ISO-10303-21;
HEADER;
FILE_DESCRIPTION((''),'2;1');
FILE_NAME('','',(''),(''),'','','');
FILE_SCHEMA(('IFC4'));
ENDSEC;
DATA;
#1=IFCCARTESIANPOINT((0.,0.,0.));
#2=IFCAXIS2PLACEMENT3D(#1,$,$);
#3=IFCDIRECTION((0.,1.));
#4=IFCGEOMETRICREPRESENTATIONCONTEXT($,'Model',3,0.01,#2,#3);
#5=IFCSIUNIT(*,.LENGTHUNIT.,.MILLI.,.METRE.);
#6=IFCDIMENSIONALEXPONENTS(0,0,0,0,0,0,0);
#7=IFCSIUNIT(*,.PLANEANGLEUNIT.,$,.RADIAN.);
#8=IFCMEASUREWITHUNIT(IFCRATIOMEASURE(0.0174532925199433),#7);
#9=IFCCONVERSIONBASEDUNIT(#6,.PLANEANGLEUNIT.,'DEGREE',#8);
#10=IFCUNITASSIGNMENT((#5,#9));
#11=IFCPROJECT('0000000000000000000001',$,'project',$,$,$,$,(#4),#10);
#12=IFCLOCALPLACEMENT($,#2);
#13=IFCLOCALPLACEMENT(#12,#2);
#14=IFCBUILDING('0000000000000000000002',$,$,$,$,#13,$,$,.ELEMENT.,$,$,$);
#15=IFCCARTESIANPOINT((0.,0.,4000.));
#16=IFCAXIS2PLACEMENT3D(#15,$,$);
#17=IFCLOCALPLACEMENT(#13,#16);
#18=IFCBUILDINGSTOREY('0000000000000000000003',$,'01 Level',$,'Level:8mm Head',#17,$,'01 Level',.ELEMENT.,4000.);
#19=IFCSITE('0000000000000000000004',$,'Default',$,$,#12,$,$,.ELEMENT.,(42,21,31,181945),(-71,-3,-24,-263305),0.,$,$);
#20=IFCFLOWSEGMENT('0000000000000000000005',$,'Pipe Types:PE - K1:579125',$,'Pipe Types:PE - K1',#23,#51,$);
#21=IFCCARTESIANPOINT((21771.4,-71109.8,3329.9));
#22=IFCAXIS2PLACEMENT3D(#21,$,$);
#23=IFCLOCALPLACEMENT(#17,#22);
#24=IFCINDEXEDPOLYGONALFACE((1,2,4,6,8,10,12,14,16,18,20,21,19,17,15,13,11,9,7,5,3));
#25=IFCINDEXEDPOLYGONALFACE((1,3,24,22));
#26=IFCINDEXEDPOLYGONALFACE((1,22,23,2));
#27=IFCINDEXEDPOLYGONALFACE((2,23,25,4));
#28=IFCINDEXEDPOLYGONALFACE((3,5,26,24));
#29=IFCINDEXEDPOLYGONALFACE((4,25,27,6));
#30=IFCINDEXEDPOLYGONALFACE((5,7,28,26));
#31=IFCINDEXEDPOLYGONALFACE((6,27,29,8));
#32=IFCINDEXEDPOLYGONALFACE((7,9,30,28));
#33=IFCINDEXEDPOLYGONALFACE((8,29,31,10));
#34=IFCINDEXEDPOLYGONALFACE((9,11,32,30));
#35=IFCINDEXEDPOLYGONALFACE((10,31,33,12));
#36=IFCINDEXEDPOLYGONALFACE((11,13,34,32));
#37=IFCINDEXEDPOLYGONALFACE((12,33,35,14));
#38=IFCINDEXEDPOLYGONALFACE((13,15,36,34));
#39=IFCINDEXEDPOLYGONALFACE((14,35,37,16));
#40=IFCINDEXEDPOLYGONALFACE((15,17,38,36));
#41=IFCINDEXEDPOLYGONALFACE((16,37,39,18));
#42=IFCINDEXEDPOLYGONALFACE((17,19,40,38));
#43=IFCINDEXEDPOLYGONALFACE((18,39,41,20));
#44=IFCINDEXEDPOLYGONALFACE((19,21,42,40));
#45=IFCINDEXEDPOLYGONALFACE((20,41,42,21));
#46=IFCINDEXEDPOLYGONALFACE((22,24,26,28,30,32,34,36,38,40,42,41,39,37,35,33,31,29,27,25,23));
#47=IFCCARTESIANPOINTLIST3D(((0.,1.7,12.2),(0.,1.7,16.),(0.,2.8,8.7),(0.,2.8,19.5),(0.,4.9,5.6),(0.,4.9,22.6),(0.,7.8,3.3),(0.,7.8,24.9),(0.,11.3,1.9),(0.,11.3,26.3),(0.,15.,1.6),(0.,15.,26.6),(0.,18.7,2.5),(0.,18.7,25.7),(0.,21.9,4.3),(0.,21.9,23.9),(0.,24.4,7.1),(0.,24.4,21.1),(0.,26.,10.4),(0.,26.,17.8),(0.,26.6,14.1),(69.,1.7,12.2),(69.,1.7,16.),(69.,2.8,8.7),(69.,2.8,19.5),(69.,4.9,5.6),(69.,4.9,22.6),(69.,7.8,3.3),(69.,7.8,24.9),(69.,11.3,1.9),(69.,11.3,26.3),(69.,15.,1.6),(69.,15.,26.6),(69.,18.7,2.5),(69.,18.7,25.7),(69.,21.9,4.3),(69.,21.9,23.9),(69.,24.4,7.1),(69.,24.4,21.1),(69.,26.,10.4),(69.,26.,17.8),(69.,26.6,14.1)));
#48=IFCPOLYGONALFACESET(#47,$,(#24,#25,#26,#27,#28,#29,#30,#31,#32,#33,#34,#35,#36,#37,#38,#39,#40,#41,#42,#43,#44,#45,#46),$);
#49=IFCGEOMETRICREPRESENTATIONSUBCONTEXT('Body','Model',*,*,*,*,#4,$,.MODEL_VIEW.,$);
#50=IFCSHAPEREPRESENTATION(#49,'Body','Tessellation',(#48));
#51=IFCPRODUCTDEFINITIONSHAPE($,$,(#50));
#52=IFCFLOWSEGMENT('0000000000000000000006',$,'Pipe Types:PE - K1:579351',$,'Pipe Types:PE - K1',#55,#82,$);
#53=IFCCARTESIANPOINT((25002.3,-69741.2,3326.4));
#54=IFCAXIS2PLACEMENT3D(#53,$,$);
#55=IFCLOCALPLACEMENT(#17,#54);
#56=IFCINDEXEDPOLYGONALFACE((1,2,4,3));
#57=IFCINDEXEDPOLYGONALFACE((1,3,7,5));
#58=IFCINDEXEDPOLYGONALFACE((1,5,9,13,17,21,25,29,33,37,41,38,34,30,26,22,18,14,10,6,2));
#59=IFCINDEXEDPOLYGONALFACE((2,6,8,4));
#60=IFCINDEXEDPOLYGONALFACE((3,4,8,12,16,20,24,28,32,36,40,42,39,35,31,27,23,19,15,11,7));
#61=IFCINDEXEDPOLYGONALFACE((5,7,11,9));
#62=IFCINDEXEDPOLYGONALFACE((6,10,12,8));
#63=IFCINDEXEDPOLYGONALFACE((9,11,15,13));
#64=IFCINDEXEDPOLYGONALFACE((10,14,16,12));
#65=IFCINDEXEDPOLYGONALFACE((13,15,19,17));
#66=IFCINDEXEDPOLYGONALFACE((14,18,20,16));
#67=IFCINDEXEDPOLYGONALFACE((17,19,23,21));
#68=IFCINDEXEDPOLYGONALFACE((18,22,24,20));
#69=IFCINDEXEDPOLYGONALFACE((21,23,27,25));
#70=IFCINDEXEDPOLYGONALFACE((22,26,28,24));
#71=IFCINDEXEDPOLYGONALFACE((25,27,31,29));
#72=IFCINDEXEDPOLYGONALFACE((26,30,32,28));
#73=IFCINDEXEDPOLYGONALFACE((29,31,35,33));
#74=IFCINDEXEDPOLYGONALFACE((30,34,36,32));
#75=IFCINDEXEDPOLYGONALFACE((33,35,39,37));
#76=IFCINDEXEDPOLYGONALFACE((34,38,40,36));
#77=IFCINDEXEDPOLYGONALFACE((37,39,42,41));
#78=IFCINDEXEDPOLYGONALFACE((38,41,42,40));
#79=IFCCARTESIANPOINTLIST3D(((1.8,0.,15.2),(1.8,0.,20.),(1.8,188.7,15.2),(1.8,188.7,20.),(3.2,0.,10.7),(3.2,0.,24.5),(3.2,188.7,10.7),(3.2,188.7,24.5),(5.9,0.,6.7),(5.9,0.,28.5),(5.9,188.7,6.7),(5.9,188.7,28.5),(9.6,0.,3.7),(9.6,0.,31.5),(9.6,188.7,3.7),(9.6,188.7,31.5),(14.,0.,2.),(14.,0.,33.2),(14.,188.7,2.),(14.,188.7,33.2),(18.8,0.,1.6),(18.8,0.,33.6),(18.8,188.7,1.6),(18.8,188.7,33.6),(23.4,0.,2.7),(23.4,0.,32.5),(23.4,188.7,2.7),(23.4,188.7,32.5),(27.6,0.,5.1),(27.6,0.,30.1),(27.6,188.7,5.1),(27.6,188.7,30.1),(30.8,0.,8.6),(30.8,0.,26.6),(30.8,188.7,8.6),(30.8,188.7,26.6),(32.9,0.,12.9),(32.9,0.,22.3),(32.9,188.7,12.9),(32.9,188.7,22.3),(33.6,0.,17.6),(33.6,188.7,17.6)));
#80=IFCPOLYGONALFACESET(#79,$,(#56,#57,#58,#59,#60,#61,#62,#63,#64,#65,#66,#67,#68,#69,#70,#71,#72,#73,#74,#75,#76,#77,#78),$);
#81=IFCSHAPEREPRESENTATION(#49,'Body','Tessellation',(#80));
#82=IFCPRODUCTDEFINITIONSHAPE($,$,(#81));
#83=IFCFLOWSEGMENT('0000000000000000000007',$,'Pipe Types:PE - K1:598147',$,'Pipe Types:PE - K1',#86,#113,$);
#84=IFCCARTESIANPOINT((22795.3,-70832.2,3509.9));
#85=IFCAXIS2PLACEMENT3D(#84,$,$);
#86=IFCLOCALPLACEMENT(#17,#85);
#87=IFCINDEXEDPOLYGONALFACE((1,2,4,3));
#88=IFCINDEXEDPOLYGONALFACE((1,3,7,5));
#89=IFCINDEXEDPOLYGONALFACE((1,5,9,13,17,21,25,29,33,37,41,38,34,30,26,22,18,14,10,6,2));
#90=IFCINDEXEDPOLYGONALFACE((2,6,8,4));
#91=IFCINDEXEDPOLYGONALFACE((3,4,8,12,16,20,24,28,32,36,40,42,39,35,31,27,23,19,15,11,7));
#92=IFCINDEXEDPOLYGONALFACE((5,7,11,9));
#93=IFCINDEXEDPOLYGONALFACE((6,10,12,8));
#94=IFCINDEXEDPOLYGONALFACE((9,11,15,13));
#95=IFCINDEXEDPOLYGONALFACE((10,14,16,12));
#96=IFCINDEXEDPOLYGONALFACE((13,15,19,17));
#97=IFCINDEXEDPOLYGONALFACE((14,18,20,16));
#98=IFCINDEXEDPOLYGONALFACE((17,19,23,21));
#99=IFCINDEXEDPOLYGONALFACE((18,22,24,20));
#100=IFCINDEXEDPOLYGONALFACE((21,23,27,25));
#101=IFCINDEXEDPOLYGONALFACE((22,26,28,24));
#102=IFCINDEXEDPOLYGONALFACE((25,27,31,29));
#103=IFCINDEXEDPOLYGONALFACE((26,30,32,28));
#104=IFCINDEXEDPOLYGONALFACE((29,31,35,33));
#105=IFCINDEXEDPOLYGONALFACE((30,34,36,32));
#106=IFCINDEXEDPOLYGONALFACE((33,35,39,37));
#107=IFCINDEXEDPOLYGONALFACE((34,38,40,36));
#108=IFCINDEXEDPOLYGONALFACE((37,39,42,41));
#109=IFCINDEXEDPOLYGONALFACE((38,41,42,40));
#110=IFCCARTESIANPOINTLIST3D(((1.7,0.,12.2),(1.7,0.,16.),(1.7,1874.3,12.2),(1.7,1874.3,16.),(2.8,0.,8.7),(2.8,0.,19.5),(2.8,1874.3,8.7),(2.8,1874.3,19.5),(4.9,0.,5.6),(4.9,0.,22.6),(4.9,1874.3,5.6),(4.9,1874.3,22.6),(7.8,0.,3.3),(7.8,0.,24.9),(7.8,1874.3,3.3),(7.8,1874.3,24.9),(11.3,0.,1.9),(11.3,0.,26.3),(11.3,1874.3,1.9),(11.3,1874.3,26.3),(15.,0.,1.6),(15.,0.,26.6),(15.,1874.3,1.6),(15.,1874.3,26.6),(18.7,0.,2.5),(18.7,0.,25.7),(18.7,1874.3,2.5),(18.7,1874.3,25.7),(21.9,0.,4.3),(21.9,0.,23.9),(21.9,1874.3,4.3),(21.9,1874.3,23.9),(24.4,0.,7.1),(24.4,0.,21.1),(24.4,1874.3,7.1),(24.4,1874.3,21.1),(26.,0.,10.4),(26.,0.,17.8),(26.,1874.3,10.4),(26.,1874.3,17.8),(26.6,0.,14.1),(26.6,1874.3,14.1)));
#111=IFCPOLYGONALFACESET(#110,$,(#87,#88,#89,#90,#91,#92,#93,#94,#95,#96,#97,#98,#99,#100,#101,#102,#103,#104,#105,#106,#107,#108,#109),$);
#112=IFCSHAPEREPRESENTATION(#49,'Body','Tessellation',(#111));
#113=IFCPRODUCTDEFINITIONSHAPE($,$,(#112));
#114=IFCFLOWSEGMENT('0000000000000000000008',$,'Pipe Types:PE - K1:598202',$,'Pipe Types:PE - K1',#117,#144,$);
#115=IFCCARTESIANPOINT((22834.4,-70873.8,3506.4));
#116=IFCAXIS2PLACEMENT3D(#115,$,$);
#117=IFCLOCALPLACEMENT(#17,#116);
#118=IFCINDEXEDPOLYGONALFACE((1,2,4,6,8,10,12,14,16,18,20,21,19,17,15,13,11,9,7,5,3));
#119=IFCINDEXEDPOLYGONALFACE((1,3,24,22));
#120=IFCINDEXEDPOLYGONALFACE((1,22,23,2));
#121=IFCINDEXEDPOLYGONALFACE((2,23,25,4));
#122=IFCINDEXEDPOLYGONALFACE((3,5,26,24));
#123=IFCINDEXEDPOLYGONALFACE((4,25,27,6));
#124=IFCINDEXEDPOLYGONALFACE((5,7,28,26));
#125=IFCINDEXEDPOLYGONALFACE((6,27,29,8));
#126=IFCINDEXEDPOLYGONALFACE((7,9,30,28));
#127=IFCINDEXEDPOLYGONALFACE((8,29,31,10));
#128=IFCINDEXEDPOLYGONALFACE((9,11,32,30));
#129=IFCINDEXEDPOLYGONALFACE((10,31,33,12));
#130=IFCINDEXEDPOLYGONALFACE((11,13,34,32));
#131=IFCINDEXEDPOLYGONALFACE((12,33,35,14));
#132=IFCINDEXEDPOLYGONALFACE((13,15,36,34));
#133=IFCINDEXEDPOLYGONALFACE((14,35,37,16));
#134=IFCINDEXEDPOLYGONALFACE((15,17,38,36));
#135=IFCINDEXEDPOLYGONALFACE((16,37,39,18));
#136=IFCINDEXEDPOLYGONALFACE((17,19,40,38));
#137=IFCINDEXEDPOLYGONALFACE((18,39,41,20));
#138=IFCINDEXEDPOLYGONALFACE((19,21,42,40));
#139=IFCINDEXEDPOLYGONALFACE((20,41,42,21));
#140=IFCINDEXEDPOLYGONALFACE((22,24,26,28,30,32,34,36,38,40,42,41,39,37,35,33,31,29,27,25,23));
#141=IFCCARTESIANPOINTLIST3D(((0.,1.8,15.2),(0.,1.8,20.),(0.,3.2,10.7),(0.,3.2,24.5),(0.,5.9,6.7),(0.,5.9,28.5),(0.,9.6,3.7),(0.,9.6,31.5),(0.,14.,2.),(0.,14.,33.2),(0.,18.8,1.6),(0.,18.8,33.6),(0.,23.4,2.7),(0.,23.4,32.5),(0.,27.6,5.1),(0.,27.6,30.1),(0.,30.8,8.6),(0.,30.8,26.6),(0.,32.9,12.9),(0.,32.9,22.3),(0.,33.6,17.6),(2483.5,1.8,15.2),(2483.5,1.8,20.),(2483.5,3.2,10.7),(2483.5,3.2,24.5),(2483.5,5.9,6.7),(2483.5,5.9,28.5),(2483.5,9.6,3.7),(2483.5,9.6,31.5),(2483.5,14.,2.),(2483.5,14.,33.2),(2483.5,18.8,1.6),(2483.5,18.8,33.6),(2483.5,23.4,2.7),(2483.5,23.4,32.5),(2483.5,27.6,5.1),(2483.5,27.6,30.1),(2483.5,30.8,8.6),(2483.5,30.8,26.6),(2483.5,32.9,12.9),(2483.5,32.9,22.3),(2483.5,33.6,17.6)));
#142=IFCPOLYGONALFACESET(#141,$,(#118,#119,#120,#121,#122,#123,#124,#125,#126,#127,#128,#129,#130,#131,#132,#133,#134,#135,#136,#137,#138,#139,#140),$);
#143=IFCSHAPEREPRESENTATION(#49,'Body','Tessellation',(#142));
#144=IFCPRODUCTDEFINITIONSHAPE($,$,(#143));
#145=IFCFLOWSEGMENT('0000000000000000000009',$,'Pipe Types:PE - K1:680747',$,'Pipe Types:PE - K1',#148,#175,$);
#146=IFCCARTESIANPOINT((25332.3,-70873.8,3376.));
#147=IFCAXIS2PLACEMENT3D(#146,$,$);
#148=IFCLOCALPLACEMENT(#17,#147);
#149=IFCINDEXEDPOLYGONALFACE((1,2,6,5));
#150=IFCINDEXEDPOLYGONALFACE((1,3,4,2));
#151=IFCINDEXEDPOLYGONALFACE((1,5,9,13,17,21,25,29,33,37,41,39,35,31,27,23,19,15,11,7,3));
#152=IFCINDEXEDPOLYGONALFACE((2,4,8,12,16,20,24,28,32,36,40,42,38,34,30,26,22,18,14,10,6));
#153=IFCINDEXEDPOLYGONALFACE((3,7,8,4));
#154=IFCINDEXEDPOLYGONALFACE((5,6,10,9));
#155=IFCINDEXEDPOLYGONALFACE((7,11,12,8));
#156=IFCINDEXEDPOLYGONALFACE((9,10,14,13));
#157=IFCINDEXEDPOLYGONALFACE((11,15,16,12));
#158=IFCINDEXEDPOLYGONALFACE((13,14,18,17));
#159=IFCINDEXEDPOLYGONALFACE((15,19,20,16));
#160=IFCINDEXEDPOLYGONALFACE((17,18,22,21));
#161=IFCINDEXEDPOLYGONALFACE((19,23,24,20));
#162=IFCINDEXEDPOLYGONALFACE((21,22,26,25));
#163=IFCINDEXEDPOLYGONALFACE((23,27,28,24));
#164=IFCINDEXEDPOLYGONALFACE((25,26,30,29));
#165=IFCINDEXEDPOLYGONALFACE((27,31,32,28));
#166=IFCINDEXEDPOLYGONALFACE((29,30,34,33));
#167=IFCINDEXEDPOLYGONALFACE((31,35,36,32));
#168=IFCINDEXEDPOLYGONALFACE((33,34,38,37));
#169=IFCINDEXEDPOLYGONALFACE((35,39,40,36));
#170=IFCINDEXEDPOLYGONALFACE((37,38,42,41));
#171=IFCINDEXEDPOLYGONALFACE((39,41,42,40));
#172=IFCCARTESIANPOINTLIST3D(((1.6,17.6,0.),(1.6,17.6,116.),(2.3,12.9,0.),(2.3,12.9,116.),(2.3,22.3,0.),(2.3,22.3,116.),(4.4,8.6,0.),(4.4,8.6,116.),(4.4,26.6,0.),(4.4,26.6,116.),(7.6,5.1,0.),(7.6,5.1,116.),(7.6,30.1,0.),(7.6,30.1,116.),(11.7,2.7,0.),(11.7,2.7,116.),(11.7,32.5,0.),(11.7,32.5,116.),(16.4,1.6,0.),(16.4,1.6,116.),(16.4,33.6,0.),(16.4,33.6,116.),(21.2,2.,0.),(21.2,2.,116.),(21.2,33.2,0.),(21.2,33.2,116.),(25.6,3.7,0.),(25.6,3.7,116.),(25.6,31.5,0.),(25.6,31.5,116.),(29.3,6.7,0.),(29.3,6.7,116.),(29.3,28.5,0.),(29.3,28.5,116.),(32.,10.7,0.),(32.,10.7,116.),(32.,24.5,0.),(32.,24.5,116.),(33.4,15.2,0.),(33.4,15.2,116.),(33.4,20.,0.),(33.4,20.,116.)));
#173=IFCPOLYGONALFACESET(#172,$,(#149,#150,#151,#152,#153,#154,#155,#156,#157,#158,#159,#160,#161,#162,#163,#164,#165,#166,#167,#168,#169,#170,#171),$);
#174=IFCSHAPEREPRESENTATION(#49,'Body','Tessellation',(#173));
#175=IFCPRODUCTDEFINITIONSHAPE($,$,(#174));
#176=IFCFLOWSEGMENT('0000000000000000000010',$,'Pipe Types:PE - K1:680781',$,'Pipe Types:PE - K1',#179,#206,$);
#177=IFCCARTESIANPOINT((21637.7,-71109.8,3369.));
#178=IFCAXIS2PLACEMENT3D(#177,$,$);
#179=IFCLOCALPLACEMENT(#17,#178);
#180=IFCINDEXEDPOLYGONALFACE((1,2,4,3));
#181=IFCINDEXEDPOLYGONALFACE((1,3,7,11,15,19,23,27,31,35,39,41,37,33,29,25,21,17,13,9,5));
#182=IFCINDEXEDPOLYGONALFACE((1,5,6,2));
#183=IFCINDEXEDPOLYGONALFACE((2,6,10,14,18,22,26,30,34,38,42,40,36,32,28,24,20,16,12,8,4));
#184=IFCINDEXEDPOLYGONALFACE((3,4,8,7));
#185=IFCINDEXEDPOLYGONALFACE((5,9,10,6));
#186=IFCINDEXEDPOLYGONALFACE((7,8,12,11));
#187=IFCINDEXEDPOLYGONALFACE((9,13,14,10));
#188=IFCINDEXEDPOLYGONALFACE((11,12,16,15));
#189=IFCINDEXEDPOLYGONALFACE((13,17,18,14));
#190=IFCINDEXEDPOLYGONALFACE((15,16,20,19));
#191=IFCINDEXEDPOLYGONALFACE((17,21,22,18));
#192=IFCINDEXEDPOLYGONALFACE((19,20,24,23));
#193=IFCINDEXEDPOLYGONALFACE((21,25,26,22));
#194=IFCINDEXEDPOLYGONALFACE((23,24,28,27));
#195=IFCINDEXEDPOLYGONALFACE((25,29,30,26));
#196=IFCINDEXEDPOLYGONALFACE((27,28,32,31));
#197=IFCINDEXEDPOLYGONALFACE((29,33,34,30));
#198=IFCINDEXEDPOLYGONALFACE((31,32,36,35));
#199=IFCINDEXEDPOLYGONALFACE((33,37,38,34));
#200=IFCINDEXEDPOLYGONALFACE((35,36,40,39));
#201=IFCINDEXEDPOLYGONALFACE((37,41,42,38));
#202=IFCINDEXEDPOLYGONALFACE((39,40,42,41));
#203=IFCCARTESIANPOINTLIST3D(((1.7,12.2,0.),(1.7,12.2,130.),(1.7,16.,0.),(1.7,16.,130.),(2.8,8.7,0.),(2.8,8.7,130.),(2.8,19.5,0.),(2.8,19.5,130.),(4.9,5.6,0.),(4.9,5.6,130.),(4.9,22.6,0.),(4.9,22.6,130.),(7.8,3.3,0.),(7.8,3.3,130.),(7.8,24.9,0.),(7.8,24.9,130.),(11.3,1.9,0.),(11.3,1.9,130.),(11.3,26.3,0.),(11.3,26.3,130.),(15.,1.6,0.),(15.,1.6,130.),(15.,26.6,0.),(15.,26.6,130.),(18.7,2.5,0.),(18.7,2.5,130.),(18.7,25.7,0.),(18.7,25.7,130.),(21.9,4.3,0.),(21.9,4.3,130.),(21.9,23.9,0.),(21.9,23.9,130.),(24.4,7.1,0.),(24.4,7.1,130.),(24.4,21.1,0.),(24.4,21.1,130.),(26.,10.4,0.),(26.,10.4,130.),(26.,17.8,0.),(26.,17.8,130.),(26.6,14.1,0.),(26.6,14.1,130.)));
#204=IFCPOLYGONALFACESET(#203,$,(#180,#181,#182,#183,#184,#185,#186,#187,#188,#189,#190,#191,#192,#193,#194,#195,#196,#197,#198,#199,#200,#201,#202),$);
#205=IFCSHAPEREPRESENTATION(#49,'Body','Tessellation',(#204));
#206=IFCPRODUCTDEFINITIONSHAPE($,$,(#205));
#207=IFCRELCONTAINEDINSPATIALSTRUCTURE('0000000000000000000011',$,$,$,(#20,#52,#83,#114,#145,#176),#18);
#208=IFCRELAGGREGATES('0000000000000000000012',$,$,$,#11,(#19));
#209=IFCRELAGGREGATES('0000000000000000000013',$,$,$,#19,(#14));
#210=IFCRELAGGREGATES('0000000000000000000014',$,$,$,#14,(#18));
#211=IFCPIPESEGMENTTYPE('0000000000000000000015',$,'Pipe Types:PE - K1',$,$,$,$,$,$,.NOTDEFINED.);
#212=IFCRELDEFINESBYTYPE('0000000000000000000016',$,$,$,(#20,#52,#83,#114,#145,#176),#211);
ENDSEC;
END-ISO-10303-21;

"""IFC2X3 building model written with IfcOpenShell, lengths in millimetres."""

from ifc_helpers import new_model, entity, si_unit, converted_unit, direction, frame, frame_2d, origin, origin_2d_with_axis, place, context, subcontext, project, spatial, circle, extrude, type_object, element, save


model = new_model("IFC2X3")

# Units and contexts
model_context = context("Model", 3, precision=0.01, world=origin(), true_north=direction((0.0, 1.0)))
body_context = subcontext(model_context, "Body", "Model", "MODEL_VIEW")
ifc_project = project(units=[si_unit("LENGTHUNIT", "METRE", prefix="MILLI"), converted_unit("PLANEANGLEUNIT", "DEGREE", entity("IfcRatioMeasure", 0.0174532925199433), si_unit("PLANEANGLEUNIT", "RADIAN"), dimensions=[0, 0, 0, 0, 0, 0, 0])], contexts=[model_context])

# Site, building, storey
site_placement = place(None, origin())
site = spatial("IfcSite", under=ifc_project, at=site_placement, Name="Default", CompositionType="ELEMENT", RefLatitude=(42, 21, 31, 181945), RefLongitude=(-71, -3, -24, -263305), RefElevation=0.0)
building_placement = place(site_placement, origin())
building = spatial("IfcBuilding", under=site, at=building_placement, CompositionType="ELEMENT")
storey_placement = place(building_placement, frame((0.0, 0.0, 4000.0)))
storey = spatial("IfcBuildingStorey", under=building, at=storey_placement, Name="01 Level", ObjectType="Level:8mm Head", LongName="01 Level", CompositionType="ELEMENT", Elevation=4000.0)

# Flow segments
pipe_segment_type = type_object("IfcPipeSegmentType", Name="Pipe Types:PE - K1", PredefinedType="NOTDEFINED")
flow_segment_1_placement = place(storey_placement, frame((21771.4, -71109.8, 3329.9)))
element("IfcFlowSegment", 1, at=flow_segment_1_placement, inside=storey, type_object=pipe_segment_type, Name="Pipe Types:PE - K1:579125", ObjectType="Pipe Types:PE - K1", context=body_context, shape_type="SweptSolid", body=[
    extrude(circle(Radius=12.5, at=frame_2d((0.0, 0.0), x_axis=(1.0, 0.0))), frame((0.0, 14.1, 14.1), z_axis=(1.0, 0.0, 0.0), x_axis=(0.0, 1.0, 0.0)), (0.0, 0.0, 1.0), 69.0),
])
flow_segment_2_placement = place(storey_placement, frame((25002.3, -69741.2, 3326.4)))
element("IfcFlowSegment", 2, at=flow_segment_2_placement, inside=storey, type_object=pipe_segment_type, Name="Pipe Types:PE - K1:579351", ObjectType="Pipe Types:PE - K1", context=body_context, shape_type="SweptSolid", body=[
    extrude(circle(Radius=16.0, at=origin_2d_with_axis()), frame((17.6, 0.0, 17.6), z_axis=(0.0, 1.0, 0.0), x_axis=(1.0, 0.0, 0.0)), (0.0, 0.0, 1.0), 188.7),
])
flow_segment_3_placement = place(storey_placement, frame((22795.3, -70832.2, 3509.9)))
element("IfcFlowSegment", 3, at=flow_segment_3_placement, inside=storey, type_object=pipe_segment_type, Name="Pipe Types:PE - K1:598147", ObjectType="Pipe Types:PE - K1", context=body_context, shape_type="SweptSolid", body=[
    extrude(circle(Radius=12.5, at=origin_2d_with_axis()), frame((14.1, 0.0, 14.1), z_axis=(0.0, 1.0, 0.0), x_axis=(1.0, 0.0, 0.0)), (0.0, 0.0, 1.0), 1874.3),
])
flow_segment_4_placement = place(storey_placement, frame((22834.4, -70873.8, 3506.4)))
element("IfcFlowSegment", 4, at=flow_segment_4_placement, inside=storey, type_object=pipe_segment_type, Name="Pipe Types:PE - K1:598202", ObjectType="Pipe Types:PE - K1", context=body_context, shape_type="SweptSolid", body=[
    extrude(circle(Radius=16.0, at=origin_2d_with_axis()), frame((0.0, 17.6, 17.6), z_axis=(1.0, 0.0, 0.0), x_axis=(0.0, 1.0, 0.0)), (0.0, 0.0, 1.0), 2483.5),
])
flow_segment_5_placement = place(storey_placement, frame((25332.3, -70873.8, 3376.0)))
element("IfcFlowSegment", 5, at=flow_segment_5_placement, inside=storey, type_object=pipe_segment_type, Name="Pipe Types:PE - K1:680747", ObjectType="Pipe Types:PE - K1", context=body_context, shape_type="SweptSolid", body=[
    extrude(circle(Radius=16.0, at=origin_2d_with_axis()), frame((17.6, 17.6, 0.0), z_axis=(0.0, 0.0, 1.0), x_axis=(-1.0, 0.0, 0.0)), (0.0, 0.0, 1.0), 116.0),
])
flow_segment_6_placement = place(storey_placement, frame((21637.7, -71109.8, 3369.0)))
element("IfcFlowSegment", 6, at=flow_segment_6_placement, inside=storey, type_object=pipe_segment_type, Name="Pipe Types:PE - K1:680781", ObjectType="Pipe Types:PE - K1", context=body_context, shape_type="SweptSolid", body=[
    extrude(circle(Radius=12.5, at=frame_2d((0.0, 0.0), x_axis=(1.0, 0.0))), frame((14.1, 14.1, 0.0)), (0.0, 0.0, 1.0), 130.0),
])

save(model, "model.ifc")
